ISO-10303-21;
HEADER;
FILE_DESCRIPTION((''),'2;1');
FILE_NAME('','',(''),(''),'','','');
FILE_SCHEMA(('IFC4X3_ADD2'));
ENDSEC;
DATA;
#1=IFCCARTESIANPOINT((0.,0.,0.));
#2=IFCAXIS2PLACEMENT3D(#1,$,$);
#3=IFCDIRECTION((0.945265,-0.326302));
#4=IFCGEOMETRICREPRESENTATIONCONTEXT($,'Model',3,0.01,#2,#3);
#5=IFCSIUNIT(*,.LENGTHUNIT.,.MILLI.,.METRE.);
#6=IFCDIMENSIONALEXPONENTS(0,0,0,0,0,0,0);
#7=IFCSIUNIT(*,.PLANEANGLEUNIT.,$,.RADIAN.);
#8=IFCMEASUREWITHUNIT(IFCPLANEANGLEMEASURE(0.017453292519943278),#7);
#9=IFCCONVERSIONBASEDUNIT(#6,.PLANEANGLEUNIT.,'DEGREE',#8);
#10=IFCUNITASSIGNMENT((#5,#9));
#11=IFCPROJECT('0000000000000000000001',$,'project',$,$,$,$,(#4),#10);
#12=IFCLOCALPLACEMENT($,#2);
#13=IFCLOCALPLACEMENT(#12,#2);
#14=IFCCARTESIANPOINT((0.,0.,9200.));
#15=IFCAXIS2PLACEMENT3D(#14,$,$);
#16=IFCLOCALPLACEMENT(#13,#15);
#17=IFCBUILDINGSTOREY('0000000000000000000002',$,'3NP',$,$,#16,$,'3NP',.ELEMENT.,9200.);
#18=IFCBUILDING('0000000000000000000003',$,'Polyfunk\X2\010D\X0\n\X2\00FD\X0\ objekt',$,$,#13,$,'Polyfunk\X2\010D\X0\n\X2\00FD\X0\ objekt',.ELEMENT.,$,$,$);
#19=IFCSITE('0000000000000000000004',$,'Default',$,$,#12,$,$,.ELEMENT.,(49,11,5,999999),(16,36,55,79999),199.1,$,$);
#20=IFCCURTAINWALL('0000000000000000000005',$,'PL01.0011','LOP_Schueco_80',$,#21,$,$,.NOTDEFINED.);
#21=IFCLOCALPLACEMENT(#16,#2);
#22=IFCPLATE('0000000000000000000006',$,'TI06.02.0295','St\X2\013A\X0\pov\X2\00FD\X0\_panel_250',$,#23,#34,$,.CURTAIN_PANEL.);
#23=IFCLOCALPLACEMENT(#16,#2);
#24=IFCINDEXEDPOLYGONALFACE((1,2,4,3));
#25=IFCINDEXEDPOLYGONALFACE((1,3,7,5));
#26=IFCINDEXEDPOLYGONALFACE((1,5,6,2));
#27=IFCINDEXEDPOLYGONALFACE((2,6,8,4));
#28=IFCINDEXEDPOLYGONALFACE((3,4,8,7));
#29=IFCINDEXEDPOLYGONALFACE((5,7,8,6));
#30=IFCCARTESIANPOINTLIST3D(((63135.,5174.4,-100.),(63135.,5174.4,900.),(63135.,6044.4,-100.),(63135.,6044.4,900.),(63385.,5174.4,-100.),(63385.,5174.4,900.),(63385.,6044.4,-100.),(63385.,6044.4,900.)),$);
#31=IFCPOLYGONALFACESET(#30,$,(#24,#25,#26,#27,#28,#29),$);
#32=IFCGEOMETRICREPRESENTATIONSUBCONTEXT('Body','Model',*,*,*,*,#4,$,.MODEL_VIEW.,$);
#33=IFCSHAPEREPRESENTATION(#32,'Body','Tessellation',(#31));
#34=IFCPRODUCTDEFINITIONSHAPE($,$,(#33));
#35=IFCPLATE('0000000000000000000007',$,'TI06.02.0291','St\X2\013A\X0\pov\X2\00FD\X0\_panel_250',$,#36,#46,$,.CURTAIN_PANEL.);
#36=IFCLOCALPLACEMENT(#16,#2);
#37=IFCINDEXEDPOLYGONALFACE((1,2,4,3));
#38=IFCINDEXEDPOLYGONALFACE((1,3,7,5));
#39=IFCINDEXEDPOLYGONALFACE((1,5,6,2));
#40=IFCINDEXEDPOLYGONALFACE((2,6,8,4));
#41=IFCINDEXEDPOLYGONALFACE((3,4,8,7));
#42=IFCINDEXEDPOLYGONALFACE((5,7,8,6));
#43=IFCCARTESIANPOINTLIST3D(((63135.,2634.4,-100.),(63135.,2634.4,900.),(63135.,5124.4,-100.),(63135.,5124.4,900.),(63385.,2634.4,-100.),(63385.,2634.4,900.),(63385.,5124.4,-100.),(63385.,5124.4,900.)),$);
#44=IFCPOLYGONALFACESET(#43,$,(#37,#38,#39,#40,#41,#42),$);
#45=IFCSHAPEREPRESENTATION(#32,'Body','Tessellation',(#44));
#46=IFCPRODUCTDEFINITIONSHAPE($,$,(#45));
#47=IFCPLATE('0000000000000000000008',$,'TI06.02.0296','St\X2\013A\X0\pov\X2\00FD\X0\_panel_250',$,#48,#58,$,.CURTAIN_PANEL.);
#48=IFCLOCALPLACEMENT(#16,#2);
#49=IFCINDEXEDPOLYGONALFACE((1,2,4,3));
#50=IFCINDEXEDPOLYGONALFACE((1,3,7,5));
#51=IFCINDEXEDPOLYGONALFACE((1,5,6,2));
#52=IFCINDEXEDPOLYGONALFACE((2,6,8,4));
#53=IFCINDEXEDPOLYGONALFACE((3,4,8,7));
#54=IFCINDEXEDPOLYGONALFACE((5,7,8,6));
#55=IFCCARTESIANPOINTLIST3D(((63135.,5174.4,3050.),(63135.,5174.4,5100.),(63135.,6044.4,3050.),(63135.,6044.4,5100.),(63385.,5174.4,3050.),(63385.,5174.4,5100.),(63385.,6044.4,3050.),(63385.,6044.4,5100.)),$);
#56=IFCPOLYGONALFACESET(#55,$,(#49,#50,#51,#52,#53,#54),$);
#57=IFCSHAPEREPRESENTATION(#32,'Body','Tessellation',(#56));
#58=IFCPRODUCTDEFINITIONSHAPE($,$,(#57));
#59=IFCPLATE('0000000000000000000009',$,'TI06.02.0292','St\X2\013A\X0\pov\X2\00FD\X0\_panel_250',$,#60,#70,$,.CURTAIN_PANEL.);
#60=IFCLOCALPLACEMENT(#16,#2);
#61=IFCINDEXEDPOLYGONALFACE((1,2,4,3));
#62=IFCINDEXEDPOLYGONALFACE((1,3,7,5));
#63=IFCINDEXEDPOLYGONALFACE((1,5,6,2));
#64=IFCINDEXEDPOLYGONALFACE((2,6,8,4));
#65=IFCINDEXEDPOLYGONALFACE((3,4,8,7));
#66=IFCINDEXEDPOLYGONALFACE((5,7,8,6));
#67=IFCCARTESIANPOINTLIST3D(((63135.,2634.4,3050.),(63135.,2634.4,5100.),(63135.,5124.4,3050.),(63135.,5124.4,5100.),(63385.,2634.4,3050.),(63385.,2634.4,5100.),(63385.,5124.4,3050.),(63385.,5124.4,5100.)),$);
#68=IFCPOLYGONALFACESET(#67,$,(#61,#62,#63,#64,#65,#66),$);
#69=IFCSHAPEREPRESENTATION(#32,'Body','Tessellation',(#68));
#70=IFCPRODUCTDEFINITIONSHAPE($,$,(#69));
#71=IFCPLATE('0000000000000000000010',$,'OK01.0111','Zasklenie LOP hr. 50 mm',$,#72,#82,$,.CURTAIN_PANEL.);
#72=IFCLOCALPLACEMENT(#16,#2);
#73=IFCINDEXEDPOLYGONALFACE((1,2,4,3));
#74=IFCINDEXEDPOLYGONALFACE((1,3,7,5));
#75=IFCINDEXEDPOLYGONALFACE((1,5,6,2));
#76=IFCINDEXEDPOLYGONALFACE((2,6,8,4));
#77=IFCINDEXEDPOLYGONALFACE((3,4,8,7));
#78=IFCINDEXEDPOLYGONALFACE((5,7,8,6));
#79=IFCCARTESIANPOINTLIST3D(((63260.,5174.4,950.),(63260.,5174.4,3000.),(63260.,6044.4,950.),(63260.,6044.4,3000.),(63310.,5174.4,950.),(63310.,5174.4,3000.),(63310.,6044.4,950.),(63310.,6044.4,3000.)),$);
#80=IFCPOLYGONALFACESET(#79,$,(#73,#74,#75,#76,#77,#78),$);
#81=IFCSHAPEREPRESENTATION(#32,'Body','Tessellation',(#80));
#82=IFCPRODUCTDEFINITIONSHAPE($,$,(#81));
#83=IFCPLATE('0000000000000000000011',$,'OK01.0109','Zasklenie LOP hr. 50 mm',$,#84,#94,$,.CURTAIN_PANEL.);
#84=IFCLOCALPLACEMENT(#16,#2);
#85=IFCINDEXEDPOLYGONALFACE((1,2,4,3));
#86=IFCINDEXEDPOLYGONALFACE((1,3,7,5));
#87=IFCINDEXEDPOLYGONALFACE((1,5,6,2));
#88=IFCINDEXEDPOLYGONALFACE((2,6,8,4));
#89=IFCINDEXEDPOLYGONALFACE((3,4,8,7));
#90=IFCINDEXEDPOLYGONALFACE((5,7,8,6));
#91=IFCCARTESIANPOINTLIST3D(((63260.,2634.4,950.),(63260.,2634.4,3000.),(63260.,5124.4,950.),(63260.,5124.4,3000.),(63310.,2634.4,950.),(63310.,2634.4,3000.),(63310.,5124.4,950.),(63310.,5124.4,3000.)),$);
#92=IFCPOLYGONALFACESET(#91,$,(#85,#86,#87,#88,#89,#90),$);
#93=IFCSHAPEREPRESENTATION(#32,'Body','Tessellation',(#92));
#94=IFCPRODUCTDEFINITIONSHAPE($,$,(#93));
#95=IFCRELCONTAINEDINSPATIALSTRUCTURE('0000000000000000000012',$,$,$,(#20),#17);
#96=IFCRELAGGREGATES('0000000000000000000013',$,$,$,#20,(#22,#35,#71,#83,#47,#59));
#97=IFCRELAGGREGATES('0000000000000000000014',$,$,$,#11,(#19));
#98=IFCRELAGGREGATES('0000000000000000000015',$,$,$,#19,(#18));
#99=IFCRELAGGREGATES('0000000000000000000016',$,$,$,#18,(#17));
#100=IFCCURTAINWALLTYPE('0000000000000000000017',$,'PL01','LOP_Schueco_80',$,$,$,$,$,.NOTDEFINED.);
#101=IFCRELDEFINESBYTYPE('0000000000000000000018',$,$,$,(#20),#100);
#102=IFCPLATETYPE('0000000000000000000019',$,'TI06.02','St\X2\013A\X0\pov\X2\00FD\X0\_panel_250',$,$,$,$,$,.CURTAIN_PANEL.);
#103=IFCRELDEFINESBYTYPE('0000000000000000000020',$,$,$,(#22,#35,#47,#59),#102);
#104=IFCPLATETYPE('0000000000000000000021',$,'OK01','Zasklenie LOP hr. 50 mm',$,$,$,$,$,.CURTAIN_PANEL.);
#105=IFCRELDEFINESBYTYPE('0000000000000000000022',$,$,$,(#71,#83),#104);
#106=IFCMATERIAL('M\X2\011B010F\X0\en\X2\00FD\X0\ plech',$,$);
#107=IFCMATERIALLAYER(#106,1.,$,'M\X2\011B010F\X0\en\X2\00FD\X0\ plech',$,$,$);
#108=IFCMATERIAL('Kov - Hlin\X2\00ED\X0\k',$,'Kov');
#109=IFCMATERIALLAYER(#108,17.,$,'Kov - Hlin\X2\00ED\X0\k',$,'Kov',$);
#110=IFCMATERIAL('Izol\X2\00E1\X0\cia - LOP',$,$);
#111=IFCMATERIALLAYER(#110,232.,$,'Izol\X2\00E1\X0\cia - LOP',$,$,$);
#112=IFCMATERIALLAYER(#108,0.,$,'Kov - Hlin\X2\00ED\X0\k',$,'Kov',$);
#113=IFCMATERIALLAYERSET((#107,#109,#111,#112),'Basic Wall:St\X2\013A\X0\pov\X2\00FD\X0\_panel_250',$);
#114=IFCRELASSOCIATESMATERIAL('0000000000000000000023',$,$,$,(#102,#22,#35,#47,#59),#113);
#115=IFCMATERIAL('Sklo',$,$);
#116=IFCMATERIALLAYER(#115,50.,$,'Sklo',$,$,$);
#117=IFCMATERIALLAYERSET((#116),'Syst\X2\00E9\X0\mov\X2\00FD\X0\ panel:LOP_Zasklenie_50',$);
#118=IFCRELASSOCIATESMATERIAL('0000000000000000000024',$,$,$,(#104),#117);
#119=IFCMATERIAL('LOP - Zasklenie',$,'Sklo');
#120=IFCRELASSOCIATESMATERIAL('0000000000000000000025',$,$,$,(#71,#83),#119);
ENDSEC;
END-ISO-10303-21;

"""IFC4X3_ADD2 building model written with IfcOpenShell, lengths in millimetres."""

from ifc_helpers import new_model, entity, si_unit, converted_unit, direction, frame, frame_2d, origin, origin_2d_with_axis, place, context, subcontext, project, spatial, rectangle, extrude, source, transform, mapped, material, layer, layer_set, layer_usage, type_object, type_shapes, element, aggregate, save


model = new_model("IFC4X3_ADD2")

# Units and contexts
model_context = context("Model", 3, precision=0.01, world=origin(), true_north=direction((0.945265, -0.326302)))
body_context = subcontext(model_context, "Body", "Model", "MODEL_VIEW")
ifc_project = project(units=[si_unit("LENGTHUNIT", "METRE", prefix="MILLI"), converted_unit("PLANEANGLEUNIT", "DEGREE", entity("IfcPlaneAngleMeasure", 0.017453292519943278), si_unit("PLANEANGLEUNIT", "RADIAN"), dimensions=[0, 0, 0, 0, 0, 0, 0])], contexts=[model_context])

# Site, building, storey
site_placement = place(None, origin())
site = spatial("IfcSite", under=ifc_project, at=site_placement, Name="Default", CompositionType="ELEMENT", RefLatitude=(49, 11, 5, 999999), RefLongitude=(16, 36, 55, 79999), RefElevation=199.1)
building_placement = place(site_placement, origin())
building = spatial("IfcBuilding", under=site, at=building_placement, Name="Polyfunkčný objekt", LongName="Polyfunkčný objekt", CompositionType="ELEMENT")
storey_placement = place(building_placement, frame((0.0, 0.0, 9200.0)))
storey = spatial("IfcBuildingStorey", under=building, at=storey_placement, Name="3NP", LongName="3NP", CompositionType="ELEMENT", Elevation=9200.0)

# Curtain wall, plates
curtain_wall_type = type_object("IfcCurtainWallType", Name="PL01", Description="LOP_Schueco_80", PredefinedType="NOTDEFINED")
curtain_wall_placement = place(storey_placement, frame((0.0, 0.0, -9200.0)))
curtain_wall = element("IfcCurtainWall", 1, at=curtain_wall_placement, inside=storey, type_object=curtain_wall_type, Name="PL01.0011", Description="LOP_Schueco_80", PredefinedType="NOTDEFINED")
ifc_material_1 = material(Name="Měďený plech")
ifc_layer_1 = layer(ifc_material_1, 1.0, Name="Měďený plech")
ifc_material_2 = material(Name="Kov - Hliník", Category="Kov")
ifc_layer_2 = layer(ifc_material_2, 17.0, Name="Kov - Hliník", Category="Kov")
ifc_material_3 = material(Name="Izolácia - LOP")
ifc_layer_3 = layer(ifc_material_3, 232.0, Name="Izolácia - LOP")
ifc_layer_4 = layer(ifc_material_2, 0.0, Name="Kov - Hliník", Category="Kov")
ifc_layer_set_1 = layer_set([ifc_layer_1, ifc_layer_2, ifc_layer_3, ifc_layer_4], Name="Basic Wall:Stĺpový_panel_250")
ifc_layer_usage_1 = layer_usage(ifc_layer_set_1, "AXIS2", "NEGATIVE", 125.0)
plate_type_1 = type_object("IfcPlateType", Name="TI06.02", Description="Stĺpový_panel_250", PredefinedType="CURTAIN_PANEL", material=ifc_layer_set_1)
plate_1_placement = place(storey_placement, frame((63260.0, 6044.4, -100.0), z_axis=(0.0, 0.0, 1.0), x_axis=(0.0, -1.0, 0.0)))
plate_1 = element("IfcPlate", 2, at=plate_1_placement, type_object=plate_type_1, material=ifc_layer_usage_1, Name="TI06.02.0295", Description="Stĺpový_panel_250", PredefinedType="CURTAIN_PANEL", context=body_context, shape_type="SweptSolid", body=[
    extrude(rectangle(XDim=250.0, YDim=870.0, at=frame_2d((0.0, 0.0), x_axis=(1.0, 0.0))), frame((435.0, 0.0, 0.0), z_axis=(0.0, 0.0, 1.0), x_axis=(0.0, 1.0, 0.0)), (0.0, 0.0, 1.0), 1000.0),
])
ifc_layer_usage_2 = layer_usage(ifc_layer_set_1, "AXIS2", "NEGATIVE", 125.0)
plate_2_placement = place(storey_placement, frame((63260.0, 5124.4, -100.0), z_axis=(0.0, 0.0, 1.0), x_axis=(0.0, -1.0, 0.0)))
plate_2 = element("IfcPlate", 3, at=plate_2_placement, type_object=plate_type_1, material=ifc_layer_usage_2, Name="TI06.02.0291", Description="Stĺpový_panel_250", PredefinedType="CURTAIN_PANEL", context=body_context, shape_type="SweptSolid", body=[
    extrude(rectangle(XDim=250.0, YDim=2490.0, at=origin_2d_with_axis()), frame((1245.0, 0.0, 0.0), z_axis=(0.0, 0.0, 1.0), x_axis=(0.0, 1.0, 0.0)), (0.0, 0.0, 1.0), 1000.0),
])
ifc_layer_usage_3 = layer_usage(ifc_layer_set_1, "AXIS2", "NEGATIVE", 125.0)
plate_3_placement = place(storey_placement, frame((63260.0, 6044.4, 3050.0), z_axis=(0.0, 0.0, 1.0), x_axis=(0.0, -1.0, 0.0)))
plate_3 = element("IfcPlate", 4, at=plate_3_placement, type_object=plate_type_1, material=ifc_layer_usage_3, Name="TI06.02.0296", Description="Stĺpový_panel_250", PredefinedType="CURTAIN_PANEL", context=body_context, shape_type="SweptSolid", body=[
    extrude(rectangle(XDim=250.0, YDim=870.0, at=frame_2d((0.0, 0.0), x_axis=(1.0, 0.0))), frame((435.0, 0.0, 0.0), z_axis=(0.0, 0.0, 1.0), x_axis=(0.0, 1.0, 0.0)), (0.0, 0.0, 1.0), 2050.0),
])
ifc_layer_usage_4 = layer_usage(ifc_layer_set_1, "AXIS2", "NEGATIVE", 125.0)
plate_4_placement = place(storey_placement, frame((63260.0, 5124.4, 3050.0), z_axis=(0.0, 0.0, 1.0), x_axis=(0.0, -1.0, 0.0)))
plate_4 = element("IfcPlate", 5, at=plate_4_placement, type_object=plate_type_1, material=ifc_layer_usage_4, Name="TI06.02.0292", Description="Stĺpový_panel_250", PredefinedType="CURTAIN_PANEL", context=body_context, shape_type="SweptSolid", body=[
    extrude(rectangle(XDim=250.0, YDim=2490.0, at=frame_2d((0.0, 0.0), x_axis=(1.0, 0.0))), frame((1245.0, 0.0, 0.0), z_axis=(0.0, 0.0, 1.0), x_axis=(0.0, 1.0, 0.0)), (0.0, 0.0, 1.0), 2050.0),
])
ifc_material_4 = material(Name="LOP - Zasklenie", Category="Sklo")
ifc_material_5 = material(Name="Sklo")
ifc_layer_5 = layer(ifc_material_5, 50.0, Name="Sklo")
ifc_layer_set_2 = layer_set([ifc_layer_5], Name="Systémový panel:LOP_Zasklenie_50")
plate_type_2 = type_object("IfcPlateType", Name="OK01", Description="Zasklenie LOP hr. 50 mm", PredefinedType="CURTAIN_PANEL", material=ifc_layer_set_2)
shared_shape_1 = source(origin(), body_context, "Body", "SweptSolid", [
    extrude(rectangle(XDim=50.0, YDim=870.0, at=origin_2d_with_axis()), frame((0.0, 25.0, 0.0), z_axis=(0.0, 0.0, 1.0), x_axis=(0.0, 1.0, 0.0)), (0.0, 0.0, 1.0), 2050.0),
])
plate_5_placement = place(curtain_wall_placement, frame((63260.0, 5609.4, 10150.0), z_axis=(0.0, 0.0, 1.0), x_axis=(0.0, -1.0, 0.0)))
plate_5 = element("IfcPlate", 6, at=plate_5_placement, type_object=plate_type_2, material=ifc_material_4, Name="OK01.0111", Description="Zasklenie LOP hr. 50 mm", PredefinedType="CURTAIN_PANEL", context=body_context, shape_type="MappedRepresentation", body=[
    mapped(shared_shape_1, transform((0.0, 0.0, 0.0), scale=1.0)),
])
shared_shape_2 = source(origin(), body_context, "Body", "SweptSolid", [
    extrude(rectangle(XDim=50.0, YDim=2490.0, at=origin_2d_with_axis()), frame((0.0, 25.0, 0.0), z_axis=(0.0, 0.0, 1.0), x_axis=(0.0, 1.0, 0.0)), (0.0, 0.0, 1.0), 2050.0),
])
type_shapes(plate_type_2, [shared_shape_1, shared_shape_2])
plate_6_placement = place(curtain_wall_placement, frame((63260.0, 3879.4, 10150.0), z_axis=(0.0, 0.0, 1.0), x_axis=(0.0, -1.0, 0.0)))
plate_6 = element("IfcPlate", 7, at=plate_6_placement, type_object=plate_type_2, material=ifc_material_4, Name="OK01.0109", Description="Zasklenie LOP hr. 50 mm", PredefinedType="CURTAIN_PANEL", context=body_context, shape_type="MappedRepresentation", body=[
    mapped(shared_shape_2, transform((0.0, 0.0, 0.0), scale=1.0)),
])
aggregate(curtain_wall, [plate_1, plate_2, plate_5, plate_6, plate_3, plate_4])

save(model, "model.ifc")
